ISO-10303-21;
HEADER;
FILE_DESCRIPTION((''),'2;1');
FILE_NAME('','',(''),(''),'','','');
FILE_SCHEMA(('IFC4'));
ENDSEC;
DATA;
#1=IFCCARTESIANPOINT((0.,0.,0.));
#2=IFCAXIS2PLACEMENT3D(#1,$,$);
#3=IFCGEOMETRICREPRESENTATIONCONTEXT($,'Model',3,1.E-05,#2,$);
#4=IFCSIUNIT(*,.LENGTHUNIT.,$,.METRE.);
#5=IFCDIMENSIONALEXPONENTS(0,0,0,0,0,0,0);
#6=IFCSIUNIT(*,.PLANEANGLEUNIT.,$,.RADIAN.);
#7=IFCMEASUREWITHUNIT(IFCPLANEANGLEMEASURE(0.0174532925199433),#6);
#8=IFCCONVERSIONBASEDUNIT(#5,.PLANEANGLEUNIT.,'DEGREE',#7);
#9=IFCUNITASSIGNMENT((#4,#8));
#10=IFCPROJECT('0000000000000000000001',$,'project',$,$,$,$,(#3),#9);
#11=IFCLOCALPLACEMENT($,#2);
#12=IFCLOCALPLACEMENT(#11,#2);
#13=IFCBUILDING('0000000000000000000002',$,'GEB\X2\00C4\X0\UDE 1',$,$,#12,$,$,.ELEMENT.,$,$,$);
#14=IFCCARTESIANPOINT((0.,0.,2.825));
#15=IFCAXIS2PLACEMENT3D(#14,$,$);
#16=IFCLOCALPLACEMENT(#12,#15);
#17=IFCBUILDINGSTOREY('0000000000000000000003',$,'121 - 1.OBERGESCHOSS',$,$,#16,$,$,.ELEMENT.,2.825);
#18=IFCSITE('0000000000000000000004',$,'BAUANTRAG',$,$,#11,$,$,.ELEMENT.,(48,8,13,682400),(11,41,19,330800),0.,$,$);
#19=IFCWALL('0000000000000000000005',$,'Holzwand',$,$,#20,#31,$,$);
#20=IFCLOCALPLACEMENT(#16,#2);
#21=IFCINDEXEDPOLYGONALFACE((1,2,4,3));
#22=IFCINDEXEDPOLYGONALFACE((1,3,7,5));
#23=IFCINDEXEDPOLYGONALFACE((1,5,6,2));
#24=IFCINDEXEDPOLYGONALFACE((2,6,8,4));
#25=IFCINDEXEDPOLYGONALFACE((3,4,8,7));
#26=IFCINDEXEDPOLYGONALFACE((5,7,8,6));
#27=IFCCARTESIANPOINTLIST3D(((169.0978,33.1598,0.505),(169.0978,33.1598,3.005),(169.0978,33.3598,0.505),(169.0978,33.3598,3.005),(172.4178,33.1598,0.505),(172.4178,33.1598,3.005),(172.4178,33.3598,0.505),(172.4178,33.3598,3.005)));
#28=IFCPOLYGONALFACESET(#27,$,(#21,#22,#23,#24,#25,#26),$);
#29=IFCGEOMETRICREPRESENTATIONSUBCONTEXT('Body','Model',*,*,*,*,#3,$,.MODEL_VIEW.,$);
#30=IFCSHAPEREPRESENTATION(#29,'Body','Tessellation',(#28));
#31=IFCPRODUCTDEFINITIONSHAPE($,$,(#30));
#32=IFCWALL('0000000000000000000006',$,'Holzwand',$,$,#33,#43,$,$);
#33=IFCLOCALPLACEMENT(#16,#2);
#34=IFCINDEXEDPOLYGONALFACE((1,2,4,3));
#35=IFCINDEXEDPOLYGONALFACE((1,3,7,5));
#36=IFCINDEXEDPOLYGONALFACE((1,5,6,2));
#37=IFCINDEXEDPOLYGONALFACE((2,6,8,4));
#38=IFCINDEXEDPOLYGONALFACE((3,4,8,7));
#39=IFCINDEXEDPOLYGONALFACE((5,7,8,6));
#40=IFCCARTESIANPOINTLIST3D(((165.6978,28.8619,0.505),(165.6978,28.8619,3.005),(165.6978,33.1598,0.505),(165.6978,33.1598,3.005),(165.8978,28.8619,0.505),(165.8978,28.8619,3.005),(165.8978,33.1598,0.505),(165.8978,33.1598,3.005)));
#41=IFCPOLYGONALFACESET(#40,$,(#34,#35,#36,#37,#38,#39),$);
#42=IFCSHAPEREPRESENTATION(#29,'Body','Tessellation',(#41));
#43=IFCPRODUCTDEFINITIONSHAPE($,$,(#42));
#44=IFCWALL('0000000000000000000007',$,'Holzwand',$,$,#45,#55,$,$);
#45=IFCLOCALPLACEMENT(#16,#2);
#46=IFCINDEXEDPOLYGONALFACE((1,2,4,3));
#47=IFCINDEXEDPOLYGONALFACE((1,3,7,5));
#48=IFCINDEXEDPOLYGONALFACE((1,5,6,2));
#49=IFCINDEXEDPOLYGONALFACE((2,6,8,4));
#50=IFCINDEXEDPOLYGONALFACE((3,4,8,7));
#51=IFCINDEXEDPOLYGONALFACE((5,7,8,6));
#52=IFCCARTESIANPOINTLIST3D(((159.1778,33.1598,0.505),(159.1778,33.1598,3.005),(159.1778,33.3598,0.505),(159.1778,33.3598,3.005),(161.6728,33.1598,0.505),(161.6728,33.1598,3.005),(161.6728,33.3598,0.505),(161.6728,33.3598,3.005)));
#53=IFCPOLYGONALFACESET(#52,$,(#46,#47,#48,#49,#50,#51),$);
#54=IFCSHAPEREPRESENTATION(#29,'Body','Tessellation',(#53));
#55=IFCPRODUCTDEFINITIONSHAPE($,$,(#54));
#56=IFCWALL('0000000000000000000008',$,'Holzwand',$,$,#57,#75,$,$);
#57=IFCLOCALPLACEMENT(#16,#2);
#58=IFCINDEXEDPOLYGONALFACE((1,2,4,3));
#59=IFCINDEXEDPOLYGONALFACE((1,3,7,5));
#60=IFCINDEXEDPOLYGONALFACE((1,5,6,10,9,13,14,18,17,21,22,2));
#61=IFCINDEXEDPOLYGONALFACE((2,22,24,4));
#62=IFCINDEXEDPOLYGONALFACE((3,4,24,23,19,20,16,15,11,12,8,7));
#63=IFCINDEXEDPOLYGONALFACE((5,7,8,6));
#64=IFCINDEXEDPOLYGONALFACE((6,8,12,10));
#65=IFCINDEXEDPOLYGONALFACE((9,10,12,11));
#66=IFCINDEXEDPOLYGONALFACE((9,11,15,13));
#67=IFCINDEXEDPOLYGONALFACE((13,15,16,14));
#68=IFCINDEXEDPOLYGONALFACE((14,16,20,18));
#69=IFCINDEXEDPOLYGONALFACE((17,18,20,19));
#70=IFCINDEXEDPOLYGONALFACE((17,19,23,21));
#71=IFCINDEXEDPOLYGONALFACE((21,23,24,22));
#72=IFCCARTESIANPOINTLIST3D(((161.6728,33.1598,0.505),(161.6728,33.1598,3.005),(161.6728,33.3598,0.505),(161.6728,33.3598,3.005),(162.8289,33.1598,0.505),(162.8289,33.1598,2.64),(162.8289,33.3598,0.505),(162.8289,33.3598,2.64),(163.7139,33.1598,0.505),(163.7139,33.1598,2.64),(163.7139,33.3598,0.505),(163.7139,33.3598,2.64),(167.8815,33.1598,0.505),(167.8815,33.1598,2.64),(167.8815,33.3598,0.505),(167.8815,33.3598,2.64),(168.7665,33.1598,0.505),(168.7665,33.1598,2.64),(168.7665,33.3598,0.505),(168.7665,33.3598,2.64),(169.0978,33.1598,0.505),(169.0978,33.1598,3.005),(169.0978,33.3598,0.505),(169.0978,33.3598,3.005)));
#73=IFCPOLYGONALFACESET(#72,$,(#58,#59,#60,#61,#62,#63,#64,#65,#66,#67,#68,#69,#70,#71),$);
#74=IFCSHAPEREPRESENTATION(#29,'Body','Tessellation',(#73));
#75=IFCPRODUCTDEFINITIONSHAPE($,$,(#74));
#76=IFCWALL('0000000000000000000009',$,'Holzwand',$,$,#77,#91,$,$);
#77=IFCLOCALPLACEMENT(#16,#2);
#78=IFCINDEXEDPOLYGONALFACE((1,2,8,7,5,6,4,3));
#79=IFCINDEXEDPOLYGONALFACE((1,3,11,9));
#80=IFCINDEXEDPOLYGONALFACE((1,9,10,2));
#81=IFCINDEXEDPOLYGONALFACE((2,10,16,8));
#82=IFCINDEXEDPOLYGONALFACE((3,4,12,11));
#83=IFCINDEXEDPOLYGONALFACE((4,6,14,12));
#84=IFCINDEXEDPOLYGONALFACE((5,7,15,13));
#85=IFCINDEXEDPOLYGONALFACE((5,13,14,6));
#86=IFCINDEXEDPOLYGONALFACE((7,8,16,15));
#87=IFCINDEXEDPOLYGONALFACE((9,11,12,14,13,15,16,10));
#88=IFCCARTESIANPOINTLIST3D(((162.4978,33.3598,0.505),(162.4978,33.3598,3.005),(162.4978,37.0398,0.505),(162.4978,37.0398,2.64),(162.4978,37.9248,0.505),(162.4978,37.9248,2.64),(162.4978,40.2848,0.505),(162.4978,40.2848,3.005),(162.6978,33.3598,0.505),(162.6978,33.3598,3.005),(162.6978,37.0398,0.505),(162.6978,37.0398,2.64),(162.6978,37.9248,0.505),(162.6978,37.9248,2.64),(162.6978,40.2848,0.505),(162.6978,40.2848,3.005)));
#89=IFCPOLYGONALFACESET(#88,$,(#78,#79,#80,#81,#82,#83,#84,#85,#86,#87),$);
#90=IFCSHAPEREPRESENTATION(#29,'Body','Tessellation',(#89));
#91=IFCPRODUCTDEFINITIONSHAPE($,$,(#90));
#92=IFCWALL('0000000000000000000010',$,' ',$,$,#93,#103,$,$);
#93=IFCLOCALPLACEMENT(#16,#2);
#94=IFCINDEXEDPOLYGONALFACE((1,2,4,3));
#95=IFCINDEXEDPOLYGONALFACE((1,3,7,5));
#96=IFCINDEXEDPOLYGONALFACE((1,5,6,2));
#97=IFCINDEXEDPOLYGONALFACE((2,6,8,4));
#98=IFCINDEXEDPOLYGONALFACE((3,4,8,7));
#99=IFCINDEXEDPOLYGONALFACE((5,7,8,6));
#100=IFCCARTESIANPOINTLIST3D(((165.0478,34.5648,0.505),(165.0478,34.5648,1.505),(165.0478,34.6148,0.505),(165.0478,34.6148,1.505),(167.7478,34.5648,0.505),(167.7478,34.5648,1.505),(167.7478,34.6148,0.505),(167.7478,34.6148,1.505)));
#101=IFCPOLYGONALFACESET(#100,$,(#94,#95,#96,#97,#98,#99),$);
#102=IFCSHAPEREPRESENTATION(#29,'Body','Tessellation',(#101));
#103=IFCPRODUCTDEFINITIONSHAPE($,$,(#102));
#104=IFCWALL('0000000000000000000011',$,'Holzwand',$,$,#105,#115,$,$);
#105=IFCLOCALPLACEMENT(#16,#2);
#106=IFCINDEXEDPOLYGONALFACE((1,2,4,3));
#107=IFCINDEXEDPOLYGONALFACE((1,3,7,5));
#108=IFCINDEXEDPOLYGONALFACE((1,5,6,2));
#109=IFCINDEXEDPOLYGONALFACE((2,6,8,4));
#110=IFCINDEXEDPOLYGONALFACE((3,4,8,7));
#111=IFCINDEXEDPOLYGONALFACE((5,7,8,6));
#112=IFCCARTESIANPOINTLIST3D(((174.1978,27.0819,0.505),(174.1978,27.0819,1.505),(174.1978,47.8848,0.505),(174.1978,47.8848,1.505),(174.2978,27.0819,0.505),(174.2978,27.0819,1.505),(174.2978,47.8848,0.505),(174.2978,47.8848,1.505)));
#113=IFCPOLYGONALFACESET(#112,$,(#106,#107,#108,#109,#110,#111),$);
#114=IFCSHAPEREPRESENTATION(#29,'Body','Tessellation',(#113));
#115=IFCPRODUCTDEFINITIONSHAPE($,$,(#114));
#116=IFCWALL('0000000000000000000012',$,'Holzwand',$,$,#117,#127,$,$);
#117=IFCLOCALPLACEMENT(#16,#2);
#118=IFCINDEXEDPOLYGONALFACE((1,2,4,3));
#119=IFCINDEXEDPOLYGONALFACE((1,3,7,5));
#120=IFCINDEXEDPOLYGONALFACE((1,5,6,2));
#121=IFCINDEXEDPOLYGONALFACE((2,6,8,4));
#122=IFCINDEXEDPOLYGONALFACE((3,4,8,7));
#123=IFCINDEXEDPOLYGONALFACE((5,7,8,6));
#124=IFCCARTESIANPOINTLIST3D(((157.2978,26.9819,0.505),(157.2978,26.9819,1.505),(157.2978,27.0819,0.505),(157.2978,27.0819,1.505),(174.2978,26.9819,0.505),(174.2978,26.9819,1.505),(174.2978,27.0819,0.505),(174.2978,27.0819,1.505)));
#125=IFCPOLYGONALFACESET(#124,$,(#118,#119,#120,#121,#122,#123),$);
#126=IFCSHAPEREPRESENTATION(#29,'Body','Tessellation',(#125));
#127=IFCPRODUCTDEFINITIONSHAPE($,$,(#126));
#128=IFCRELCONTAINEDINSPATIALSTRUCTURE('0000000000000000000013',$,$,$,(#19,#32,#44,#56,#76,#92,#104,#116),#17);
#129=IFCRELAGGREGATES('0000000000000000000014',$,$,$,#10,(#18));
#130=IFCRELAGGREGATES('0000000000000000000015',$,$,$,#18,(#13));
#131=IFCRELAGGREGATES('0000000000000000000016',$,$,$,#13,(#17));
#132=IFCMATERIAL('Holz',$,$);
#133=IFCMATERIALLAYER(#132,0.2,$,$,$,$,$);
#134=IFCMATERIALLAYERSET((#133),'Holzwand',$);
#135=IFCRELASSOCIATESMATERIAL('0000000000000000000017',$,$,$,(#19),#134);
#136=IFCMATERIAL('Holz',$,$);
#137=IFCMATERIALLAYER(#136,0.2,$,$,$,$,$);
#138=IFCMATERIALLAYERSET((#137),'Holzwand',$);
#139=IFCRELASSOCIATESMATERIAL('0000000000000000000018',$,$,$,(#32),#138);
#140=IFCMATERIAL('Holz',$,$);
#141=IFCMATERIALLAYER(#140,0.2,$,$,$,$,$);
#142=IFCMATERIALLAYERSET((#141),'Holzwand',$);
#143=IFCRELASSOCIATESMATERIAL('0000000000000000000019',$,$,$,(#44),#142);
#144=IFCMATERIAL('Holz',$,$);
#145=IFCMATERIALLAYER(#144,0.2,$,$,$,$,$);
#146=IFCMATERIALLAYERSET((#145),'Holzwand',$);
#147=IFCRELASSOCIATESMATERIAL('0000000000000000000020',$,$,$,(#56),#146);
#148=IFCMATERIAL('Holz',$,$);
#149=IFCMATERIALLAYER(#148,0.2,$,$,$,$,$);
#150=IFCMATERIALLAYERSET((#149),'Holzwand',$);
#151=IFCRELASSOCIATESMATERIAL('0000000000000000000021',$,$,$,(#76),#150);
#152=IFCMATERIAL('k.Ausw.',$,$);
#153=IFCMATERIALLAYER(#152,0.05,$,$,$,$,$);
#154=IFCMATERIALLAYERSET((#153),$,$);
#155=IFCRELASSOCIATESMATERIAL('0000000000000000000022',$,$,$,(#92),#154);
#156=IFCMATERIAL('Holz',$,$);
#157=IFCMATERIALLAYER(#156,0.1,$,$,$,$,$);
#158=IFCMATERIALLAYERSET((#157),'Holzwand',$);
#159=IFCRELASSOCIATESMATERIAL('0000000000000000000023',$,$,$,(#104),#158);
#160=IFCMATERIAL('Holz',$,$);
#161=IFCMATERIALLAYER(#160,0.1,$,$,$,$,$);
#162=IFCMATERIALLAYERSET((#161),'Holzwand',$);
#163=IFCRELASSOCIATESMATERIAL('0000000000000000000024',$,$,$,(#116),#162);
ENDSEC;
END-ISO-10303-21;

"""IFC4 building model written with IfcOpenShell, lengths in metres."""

from ifc_helpers import new_model, entity, si_unit, converted_unit, frame, frame_2d, origin, origin_with_axes, place, context, subcontext, project, spatial, polyline, rectangle, outline, extrude, material, layer, layer_set, layer_usage, element, save


model = new_model("IFC4")

# Units and contexts
model_context = context("Model", 3, precision=1e-05, world=origin())
body_context = subcontext(model_context, "Body", "Model", "MODEL_VIEW")
ifc_project = project(units=[si_unit("LENGTHUNIT", "METRE"), converted_unit("PLANEANGLEUNIT", "DEGREE", entity("IfcPlaneAngleMeasure", 0.0174532925199433), si_unit("PLANEANGLEUNIT", "RADIAN"), dimensions=[0, 0, 0, 0, 0, 0, 0])], contexts=[model_context])

# Site, building, storey
site_placement = place(None, origin())
site = spatial("IfcSite", under=ifc_project, at=site_placement, Name="BAUANTRAG", CompositionType="ELEMENT", RefLatitude=(48, 8, 13, 682400), RefLongitude=(11, 41, 19, 330800), RefElevation=0.0)
building_placement = place(site_placement, origin())
building = spatial("IfcBuilding", under=site, at=building_placement, Name="GEBÄUDE 1", CompositionType="ELEMENT")
storey_placement = place(building_placement, frame((0.0, 0.0, 2.825)))
storey = spatial("IfcBuildingStorey", under=building, at=storey_placement, Name="121 - 1.OBERGESCHOSS", CompositionType="ELEMENT", Elevation=2.825)

# Walls
ifc_material_1 = material(Name="Holz")
ifc_layer_1 = layer(ifc_material_1, 0.2)
ifc_layer_set_1 = layer_set([ifc_layer_1], Name="Holzwand")
ifc_layer_usage_1 = layer_usage(ifc_layer_set_1, "AXIS2", "POSITIVE", 0.0)
wall_1_placement = place(storey_placement, frame((169.0978, 33.1598, 0.505)))
element("IfcWall", 1, at=wall_1_placement, inside=storey, material=ifc_layer_usage_1, Name="Holzwand", context=body_context, shape_type="SweptSolid", body=[
    extrude(rectangle(XDim=3.32, YDim=0.2, at=frame_2d((1.66, 0.1), x_axis=(1.0, 0.0))), origin_with_axes(), (0.0, 0.0, 1.0), 2.5),
])
ifc_material_2 = material(Name="Holz")
ifc_layer_2 = layer(ifc_material_2, 0.2)
ifc_layer_set_2 = layer_set([ifc_layer_2], Name="Holzwand")
ifc_layer_usage_2 = layer_usage(ifc_layer_set_2, "AXIS2", "POSITIVE", 0.0)
wall_2_placement = place(storey_placement, frame((165.6978, 33.1598, 0.505), z_axis=(0.0, 0.0, 1.0), x_axis=(0.0, -1.0, 0.0)))
element("IfcWall", 2, at=wall_2_placement, inside=storey, material=ifc_layer_usage_2, Name="Holzwand", context=body_context, shape_type="SweptSolid", body=[
    extrude(rectangle(XDim=4.2979, YDim=0.2, at=frame_2d((2.1489, 0.1), x_axis=(1.0, 0.0))), origin_with_axes(), (0.0, 0.0, 1.0), 2.5),
])
ifc_material_3 = material(Name="Holz")
ifc_layer_3 = layer(ifc_material_3, 0.2)
ifc_layer_set_3 = layer_set([ifc_layer_3], Name="Holzwand")
ifc_layer_usage_3 = layer_usage(ifc_layer_set_3, "AXIS2", "POSITIVE", 0.0)
wall_3_placement = place(storey_placement, frame((159.1778, 33.1598, 0.505)))
element("IfcWall", 3, at=wall_3_placement, inside=storey, material=ifc_layer_usage_3, Name="Holzwand", context=body_context, shape_type="SweptSolid", body=[
    extrude(rectangle(XDim=2.495, YDim=0.2, at=frame_2d((1.2475, 0.1), x_axis=(1.0, 0.0))), origin_with_axes(), (0.0, 0.0, 1.0), 2.5),
])

# Wall, openings
ifc_material_4 = material(Name="Holz")
ifc_layer_4 = layer(ifc_material_4, 0.2)
ifc_layer_set_4 = layer_set([ifc_layer_4], Name="Holzwand")
ifc_layer_usage_4 = layer_usage(ifc_layer_set_4, "AXIS2", "POSITIVE", 0.0)
wall_4_placement = place(storey_placement, frame((169.0978, 33.3598, 0.505), z_axis=(0.0, 0.0, 1.0), x_axis=(-1.0, 0.0, 0.0)))
wall_4 = element("IfcWall", 4, at=wall_4_placement, inside=storey, material=ifc_layer_usage_4, Name="Holzwand", context=body_context, shape_type="SweptSolid", body=[
    extrude(rectangle(XDim=7.425, YDim=0.2, at=frame_2d((3.7125, 0.1), x_axis=(1.0, 0.0))), origin_with_axes(), (0.0, 0.0, 1.0), 2.5),
])
opening_1_placement = place(wall_4_placement, frame((6.2689, 0.2, -0.15), z_axis=(0.0, -1.0, 0.0), x_axis=(0.0, 0.0, 1.0)))
element("IfcOpeningElement", 5, at=opening_1_placement, cuts=wall_4, ObjectType="Opening", context=body_context, shape_type="SweptSolid", body=[
    extrude(outline(polyline([(0.0, 0.885), (2.285, 0.885), (2.285, 0.0), (0.0, 0.0), (0.0, 0.885)])), origin_with_axes(), (0.0, 0.0, 1.0), 0.2),
])
opening_2_placement = place(wall_4_placement, frame((1.2163, 0.2, -0.15), z_axis=(0.0, -1.0, 0.0), x_axis=(0.0, 0.0, 1.0)))
element("IfcOpeningElement", 6, at=opening_2_placement, cuts=wall_4, ObjectType="Opening", context=body_context, shape_type="SweptSolid", body=[
    extrude(outline(polyline([(0.0, 0.885), (2.285, 0.885), (2.285, 0.0), (0.0, 0.0), (0.0, 0.885)])), origin_with_axes(), (0.0, 0.0, 1.0), 0.2),
])

# Wall, opening
ifc_material_5 = material(Name="Holz")
ifc_layer_5 = layer(ifc_material_5, 0.2)
ifc_layer_set_5 = layer_set([ifc_layer_5], Name="Holzwand")
ifc_layer_usage_5 = layer_usage(ifc_layer_set_5, "AXIS2", "POSITIVE", 0.0)
wall_5_placement = place(storey_placement, frame((162.6978, 33.3598, 0.505), z_axis=(0.0, 0.0, 1.0), x_axis=(0.0, 1.0, 0.0)))
wall_5 = element("IfcWall", 7, at=wall_5_placement, inside=storey, material=ifc_layer_usage_5, Name="Holzwand", context=body_context, shape_type="SweptSolid", body=[
    extrude(rectangle(XDim=6.925, YDim=0.2, at=frame_2d((3.4625, 0.1), x_axis=(1.0, 0.0))), origin_with_axes(), (0.0, 0.0, 1.0), 2.5),
])
opening_3_placement = place(wall_5_placement, frame((3.68, 0.0, -0.15), z_axis=(0.0, 1.0, 0.0), x_axis=(0.0, 0.0, 1.0)))
element("IfcOpeningElement", 8, at=opening_3_placement, cuts=wall_5, ObjectType="Opening", context=body_context, shape_type="SweptSolid", body=[
    extrude(outline(polyline([(0.0, 0.885), (2.285, 0.885), (2.285, 0.0), (0.0, 0.0), (0.0, 0.885)])), origin_with_axes(), (0.0, 0.0, 1.0), 0.2),
])

# Walls
ifc_material_6 = material(Name="k.Ausw.")
ifc_layer_6 = layer(ifc_material_6, 0.05)
ifc_layer_set_6 = layer_set([ifc_layer_6])
ifc_layer_usage_6 = layer_usage(ifc_layer_set_6, "AXIS2", "POSITIVE", 0.0)
wall_6_placement = place(storey_placement, frame((165.0478, 34.5648, 0.505), z_axis=(0.0, 0.0, 1.0), x_axis=(1.0, 0.0, 0.0)))
element("IfcWall", 9, at=wall_6_placement, inside=storey, material=ifc_layer_usage_6, Name=" ", context=body_context, shape_type="SweptSolid", body=[
    extrude(rectangle(XDim=2.7, YDim=0.05, at=frame_2d((1.35, 0.025), x_axis=(1.0, 0.0))), origin_with_axes(), (0.0, 0.0, 1.0), 1.0),
])
ifc_material_7 = material(Name="Holz")
ifc_layer_7 = layer(ifc_material_7, 0.1)
ifc_layer_set_7 = layer_set([ifc_layer_7], Name="Holzwand")
ifc_layer_usage_7 = layer_usage(ifc_layer_set_7, "AXIS2", "POSITIVE", 0.0)
wall_7_placement = place(storey_placement, frame((174.2978, 27.0819, 0.505), z_axis=(0.0, 0.0, 1.0), x_axis=(0.0, 1.0, 0.0)))
element("IfcWall", 10, at=wall_7_placement, inside=storey, material=ifc_layer_usage_7, Name="Holzwand", context=body_context, shape_type="SweptSolid", body=[
    extrude(rectangle(XDim=20.8029, YDim=0.1, at=frame_2d((10.4014, 0.05), x_axis=(1.0, 0.0))), origin_with_axes(), (0.0, 0.0, 1.0), 1.0),
])
ifc_material_8 = material(Name="Holz")
ifc_layer_8 = layer(ifc_material_8, 0.1)
ifc_layer_set_8 = layer_set([ifc_layer_8], Name="Holzwand")
ifc_layer_usage_8 = layer_usage(ifc_layer_set_8, "AXIS2", "POSITIVE", 0.0)
wall_8_placement = place(storey_placement, frame((157.2978, 26.9819, 0.505)))
element("IfcWall", 11, at=wall_8_placement, inside=storey, material=ifc_layer_usage_8, Name="Holzwand", context=body_context, shape_type="SweptSolid", body=[
    extrude(rectangle(XDim=17.0, YDim=0.1, at=frame_2d((8.5, 0.05), x_axis=(1.0, 0.0))), origin_with_axes(), (0.0, 0.0, 1.0), 1.0),
])

save(model, "model.ifc")
